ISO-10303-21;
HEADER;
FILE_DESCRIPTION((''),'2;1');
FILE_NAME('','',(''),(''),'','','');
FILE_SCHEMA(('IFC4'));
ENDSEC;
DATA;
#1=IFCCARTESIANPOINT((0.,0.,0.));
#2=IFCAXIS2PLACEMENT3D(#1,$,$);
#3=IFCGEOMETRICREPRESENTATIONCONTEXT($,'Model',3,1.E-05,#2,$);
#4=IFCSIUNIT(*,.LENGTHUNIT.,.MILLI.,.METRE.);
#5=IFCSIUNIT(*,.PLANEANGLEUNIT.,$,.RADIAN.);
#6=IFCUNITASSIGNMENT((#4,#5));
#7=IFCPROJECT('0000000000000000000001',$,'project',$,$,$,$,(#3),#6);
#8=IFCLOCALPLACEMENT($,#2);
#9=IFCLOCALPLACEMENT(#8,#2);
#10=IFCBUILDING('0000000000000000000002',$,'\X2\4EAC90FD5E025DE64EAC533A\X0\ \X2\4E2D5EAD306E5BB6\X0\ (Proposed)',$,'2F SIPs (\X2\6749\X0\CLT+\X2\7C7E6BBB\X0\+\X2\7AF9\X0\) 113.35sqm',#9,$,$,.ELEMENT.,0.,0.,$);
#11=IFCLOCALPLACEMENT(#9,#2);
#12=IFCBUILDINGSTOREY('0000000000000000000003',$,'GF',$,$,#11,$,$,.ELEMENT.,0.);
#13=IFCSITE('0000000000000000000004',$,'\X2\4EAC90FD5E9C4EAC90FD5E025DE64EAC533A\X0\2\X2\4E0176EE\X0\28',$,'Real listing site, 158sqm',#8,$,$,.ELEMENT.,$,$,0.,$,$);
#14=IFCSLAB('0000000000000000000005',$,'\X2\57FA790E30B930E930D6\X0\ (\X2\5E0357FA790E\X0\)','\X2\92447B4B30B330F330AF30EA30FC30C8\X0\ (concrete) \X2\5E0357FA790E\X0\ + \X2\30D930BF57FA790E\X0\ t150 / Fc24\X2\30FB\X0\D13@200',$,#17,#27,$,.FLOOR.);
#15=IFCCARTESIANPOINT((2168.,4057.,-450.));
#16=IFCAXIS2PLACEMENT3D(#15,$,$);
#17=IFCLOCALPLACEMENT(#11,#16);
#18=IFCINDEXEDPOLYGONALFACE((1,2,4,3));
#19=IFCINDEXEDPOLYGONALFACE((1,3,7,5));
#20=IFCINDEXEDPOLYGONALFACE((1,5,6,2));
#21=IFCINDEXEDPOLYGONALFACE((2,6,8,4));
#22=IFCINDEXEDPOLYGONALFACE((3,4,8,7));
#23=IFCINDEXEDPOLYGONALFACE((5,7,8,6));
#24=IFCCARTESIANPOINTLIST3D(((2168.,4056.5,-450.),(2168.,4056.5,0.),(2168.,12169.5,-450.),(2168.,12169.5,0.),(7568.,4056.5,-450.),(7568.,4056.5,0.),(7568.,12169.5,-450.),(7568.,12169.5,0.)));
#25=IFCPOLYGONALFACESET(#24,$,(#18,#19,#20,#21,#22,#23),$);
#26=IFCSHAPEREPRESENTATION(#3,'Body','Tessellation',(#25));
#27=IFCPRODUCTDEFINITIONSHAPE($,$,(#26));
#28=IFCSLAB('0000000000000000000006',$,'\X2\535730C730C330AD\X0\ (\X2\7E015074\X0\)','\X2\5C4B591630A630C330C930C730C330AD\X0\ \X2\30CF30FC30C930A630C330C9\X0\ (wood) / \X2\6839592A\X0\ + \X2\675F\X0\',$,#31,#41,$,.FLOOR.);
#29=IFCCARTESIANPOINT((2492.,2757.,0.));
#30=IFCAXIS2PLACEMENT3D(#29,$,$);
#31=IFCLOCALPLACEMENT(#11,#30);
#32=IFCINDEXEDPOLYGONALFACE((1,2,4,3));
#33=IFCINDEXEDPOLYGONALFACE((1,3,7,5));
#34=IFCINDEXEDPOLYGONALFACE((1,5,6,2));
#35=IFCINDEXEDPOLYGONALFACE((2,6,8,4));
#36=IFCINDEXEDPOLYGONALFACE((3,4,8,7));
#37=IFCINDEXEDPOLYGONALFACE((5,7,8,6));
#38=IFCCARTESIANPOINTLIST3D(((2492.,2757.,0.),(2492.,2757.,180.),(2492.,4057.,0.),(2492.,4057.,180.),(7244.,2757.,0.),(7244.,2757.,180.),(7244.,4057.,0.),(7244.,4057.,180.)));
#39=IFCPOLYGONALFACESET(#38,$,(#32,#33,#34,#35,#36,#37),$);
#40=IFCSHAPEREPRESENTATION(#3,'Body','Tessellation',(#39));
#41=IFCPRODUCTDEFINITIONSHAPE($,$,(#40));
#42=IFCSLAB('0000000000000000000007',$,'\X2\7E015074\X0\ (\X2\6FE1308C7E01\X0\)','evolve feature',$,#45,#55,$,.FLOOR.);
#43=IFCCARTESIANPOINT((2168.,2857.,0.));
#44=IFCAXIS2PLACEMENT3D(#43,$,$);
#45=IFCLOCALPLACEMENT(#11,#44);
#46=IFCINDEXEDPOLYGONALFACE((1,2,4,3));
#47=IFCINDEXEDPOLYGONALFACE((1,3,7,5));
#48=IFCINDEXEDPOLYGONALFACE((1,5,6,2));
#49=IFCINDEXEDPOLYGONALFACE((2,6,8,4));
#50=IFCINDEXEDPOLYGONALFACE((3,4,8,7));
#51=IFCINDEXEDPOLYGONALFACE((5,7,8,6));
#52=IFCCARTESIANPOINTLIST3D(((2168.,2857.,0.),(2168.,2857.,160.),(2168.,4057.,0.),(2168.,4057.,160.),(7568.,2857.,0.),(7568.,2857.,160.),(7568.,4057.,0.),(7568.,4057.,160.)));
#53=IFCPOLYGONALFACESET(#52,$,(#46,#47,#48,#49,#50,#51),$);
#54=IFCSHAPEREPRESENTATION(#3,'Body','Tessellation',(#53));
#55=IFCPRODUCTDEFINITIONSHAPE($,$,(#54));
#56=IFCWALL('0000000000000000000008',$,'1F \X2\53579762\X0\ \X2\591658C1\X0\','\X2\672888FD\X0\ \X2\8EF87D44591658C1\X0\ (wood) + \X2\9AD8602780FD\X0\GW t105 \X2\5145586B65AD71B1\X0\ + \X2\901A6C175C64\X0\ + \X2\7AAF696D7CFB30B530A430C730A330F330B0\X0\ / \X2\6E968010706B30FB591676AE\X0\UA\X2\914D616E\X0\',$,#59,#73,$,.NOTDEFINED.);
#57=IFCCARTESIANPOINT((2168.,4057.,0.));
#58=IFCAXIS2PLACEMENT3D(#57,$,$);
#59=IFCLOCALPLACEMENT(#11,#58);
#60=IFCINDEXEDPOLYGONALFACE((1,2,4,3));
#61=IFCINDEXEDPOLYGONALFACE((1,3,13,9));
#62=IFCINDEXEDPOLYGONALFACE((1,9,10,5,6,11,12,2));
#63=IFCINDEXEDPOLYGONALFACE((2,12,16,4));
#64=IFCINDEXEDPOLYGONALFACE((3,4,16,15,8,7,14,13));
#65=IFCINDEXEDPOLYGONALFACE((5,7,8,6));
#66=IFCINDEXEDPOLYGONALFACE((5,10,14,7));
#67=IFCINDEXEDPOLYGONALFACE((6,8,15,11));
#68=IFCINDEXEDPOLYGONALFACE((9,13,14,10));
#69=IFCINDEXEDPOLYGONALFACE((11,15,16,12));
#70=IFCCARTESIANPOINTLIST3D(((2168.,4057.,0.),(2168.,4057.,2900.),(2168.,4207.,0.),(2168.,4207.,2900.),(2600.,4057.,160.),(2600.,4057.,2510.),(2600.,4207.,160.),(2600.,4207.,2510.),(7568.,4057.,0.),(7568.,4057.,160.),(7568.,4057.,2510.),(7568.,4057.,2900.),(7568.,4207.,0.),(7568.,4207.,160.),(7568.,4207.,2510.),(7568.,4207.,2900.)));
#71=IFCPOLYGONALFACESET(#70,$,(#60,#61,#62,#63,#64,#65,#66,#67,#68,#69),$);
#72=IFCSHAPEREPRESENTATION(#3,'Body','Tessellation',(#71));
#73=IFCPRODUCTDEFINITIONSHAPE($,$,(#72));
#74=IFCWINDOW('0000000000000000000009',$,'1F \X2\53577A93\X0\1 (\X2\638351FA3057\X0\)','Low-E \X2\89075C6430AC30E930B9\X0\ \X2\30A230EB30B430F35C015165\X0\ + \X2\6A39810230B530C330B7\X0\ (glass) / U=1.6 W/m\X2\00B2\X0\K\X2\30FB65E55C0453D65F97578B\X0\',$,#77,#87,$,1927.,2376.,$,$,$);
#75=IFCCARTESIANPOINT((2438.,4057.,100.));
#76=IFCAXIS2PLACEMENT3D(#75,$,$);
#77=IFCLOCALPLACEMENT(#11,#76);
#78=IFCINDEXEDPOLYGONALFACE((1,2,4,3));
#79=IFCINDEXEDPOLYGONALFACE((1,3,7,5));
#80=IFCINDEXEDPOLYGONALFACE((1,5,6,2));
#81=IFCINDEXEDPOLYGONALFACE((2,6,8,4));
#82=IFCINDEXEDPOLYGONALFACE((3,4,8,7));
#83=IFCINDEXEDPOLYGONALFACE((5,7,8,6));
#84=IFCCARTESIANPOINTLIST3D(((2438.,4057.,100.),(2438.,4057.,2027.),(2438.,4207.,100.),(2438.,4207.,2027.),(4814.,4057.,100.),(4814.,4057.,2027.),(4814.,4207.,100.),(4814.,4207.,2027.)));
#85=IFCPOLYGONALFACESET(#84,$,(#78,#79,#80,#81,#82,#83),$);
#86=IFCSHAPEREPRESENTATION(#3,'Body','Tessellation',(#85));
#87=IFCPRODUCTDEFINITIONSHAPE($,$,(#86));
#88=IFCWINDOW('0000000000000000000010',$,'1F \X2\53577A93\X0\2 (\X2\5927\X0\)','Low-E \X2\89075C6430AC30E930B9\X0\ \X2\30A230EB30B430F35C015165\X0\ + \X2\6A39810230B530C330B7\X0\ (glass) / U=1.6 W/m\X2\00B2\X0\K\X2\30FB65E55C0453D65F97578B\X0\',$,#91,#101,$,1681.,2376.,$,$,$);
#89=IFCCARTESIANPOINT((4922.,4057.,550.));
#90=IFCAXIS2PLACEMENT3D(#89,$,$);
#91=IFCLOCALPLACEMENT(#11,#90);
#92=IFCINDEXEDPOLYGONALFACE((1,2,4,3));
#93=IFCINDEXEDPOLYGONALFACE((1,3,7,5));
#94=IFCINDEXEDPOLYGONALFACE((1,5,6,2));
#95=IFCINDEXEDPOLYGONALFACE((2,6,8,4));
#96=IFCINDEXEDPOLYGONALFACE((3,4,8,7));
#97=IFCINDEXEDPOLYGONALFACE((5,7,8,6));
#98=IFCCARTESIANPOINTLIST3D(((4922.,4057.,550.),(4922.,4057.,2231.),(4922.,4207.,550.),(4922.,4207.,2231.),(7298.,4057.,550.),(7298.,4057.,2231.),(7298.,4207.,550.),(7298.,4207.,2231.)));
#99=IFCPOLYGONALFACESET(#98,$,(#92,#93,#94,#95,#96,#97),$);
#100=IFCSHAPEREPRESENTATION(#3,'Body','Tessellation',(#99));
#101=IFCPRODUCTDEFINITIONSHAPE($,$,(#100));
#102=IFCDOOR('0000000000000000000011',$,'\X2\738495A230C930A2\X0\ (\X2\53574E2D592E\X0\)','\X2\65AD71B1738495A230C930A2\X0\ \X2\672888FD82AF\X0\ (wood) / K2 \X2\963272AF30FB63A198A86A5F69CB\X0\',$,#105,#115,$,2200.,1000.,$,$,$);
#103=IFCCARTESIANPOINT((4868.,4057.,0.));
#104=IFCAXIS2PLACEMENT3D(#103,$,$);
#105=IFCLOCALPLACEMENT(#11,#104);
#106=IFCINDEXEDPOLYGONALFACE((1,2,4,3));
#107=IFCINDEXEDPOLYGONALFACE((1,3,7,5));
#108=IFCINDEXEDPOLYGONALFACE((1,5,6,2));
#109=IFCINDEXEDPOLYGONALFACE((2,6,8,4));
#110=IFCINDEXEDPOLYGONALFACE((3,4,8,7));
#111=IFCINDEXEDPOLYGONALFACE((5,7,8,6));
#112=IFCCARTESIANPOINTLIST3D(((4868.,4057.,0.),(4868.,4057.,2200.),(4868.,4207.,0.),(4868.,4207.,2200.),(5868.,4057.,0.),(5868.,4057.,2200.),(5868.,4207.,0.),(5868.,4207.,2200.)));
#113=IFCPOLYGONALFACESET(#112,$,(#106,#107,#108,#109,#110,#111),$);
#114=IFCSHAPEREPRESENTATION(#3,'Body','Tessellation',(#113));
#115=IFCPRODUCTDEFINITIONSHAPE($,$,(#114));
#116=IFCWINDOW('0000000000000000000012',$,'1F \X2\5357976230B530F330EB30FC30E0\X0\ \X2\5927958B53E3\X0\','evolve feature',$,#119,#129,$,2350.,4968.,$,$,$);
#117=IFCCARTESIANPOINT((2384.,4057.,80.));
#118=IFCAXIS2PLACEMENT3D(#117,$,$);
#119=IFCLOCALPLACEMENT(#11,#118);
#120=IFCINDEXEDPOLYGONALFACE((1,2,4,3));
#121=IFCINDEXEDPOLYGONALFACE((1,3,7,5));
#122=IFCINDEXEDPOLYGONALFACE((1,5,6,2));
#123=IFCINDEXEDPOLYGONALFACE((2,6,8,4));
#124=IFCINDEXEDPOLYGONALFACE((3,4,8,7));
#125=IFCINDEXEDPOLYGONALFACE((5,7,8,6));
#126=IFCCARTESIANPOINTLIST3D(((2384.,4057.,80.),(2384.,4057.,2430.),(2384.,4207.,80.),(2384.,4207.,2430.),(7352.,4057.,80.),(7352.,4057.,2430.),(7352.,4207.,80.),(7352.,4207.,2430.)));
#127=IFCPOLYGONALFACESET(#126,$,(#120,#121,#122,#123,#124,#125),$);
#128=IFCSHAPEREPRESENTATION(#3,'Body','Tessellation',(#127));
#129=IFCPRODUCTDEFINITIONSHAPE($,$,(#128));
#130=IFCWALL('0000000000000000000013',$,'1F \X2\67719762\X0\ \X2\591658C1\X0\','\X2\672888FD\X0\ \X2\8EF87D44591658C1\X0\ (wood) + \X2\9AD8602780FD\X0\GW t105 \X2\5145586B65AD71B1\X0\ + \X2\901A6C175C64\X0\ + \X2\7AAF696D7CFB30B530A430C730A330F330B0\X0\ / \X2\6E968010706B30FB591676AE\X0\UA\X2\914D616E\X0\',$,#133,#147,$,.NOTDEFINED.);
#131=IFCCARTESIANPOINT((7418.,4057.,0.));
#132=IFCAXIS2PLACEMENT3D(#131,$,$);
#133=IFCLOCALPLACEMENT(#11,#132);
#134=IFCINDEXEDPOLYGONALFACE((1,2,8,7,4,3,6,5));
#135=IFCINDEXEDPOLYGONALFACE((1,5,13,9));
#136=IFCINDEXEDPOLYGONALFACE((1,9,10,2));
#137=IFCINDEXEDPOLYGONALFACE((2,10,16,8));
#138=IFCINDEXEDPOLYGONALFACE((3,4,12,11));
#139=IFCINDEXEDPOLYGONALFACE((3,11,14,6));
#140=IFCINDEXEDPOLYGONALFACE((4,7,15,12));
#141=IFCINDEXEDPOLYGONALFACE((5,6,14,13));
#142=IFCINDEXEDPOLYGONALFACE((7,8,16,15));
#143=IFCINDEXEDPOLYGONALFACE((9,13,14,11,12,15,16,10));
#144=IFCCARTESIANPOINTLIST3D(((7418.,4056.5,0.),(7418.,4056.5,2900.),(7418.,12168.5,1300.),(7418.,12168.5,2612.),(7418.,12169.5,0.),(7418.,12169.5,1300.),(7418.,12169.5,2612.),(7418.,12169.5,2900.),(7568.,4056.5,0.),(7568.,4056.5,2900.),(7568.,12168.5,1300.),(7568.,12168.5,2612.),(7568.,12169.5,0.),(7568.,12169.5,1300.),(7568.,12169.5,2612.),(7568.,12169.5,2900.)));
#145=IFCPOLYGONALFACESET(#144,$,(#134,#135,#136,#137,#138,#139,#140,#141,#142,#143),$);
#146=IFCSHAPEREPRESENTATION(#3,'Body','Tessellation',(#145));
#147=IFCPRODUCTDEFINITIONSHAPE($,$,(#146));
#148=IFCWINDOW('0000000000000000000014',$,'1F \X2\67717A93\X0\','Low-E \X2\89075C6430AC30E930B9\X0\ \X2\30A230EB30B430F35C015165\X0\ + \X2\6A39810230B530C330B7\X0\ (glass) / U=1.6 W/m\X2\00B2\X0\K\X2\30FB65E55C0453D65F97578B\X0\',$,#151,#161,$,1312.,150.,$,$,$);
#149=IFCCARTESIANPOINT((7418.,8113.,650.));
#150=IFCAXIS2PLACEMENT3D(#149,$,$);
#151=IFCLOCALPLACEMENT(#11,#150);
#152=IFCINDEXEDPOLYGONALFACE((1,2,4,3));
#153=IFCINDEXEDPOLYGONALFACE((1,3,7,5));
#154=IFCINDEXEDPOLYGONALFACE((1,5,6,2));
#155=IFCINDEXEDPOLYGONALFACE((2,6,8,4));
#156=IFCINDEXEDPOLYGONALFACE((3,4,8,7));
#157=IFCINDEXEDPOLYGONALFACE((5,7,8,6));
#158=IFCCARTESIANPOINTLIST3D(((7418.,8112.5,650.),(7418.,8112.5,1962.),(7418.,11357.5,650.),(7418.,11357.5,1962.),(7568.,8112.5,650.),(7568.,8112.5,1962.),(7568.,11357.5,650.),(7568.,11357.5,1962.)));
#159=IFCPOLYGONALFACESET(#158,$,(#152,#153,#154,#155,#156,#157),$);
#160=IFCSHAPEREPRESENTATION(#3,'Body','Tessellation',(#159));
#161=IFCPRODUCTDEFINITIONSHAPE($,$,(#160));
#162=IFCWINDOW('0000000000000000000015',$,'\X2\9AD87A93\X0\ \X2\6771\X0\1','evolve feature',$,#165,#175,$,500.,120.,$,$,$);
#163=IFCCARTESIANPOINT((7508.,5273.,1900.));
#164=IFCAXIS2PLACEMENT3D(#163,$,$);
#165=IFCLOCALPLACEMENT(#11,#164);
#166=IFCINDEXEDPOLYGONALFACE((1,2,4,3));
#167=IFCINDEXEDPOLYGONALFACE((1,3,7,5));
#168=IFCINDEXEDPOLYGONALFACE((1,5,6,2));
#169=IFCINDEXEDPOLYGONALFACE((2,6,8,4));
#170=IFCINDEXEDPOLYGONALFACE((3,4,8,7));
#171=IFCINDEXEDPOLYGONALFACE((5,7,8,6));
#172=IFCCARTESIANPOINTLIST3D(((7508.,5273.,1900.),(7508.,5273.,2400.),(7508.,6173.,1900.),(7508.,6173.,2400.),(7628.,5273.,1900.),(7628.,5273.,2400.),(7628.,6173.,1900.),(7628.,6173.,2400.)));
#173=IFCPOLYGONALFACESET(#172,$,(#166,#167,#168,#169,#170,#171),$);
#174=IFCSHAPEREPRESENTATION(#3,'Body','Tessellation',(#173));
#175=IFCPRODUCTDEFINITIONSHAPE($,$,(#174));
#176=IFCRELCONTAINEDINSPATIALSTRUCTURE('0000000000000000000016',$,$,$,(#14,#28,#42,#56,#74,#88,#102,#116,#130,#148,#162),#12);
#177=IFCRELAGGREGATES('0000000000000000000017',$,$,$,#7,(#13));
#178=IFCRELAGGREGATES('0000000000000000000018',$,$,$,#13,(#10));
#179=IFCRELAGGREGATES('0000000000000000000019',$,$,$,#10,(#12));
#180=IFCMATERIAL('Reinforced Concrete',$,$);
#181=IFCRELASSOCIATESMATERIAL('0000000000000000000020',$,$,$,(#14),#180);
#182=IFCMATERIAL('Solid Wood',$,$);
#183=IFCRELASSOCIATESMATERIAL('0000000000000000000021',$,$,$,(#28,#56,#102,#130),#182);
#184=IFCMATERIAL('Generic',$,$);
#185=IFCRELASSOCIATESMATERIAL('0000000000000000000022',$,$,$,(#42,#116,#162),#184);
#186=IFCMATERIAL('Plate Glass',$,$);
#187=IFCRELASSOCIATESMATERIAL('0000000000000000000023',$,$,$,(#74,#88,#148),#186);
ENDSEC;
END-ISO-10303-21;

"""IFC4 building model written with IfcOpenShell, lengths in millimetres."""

from ifc_helpers import new_model, si_unit, frame, frame_2d, origin, place, context, project, spatial, rectangle, extrude, material, element, fill, save


model = new_model("IFC4")

# Units and contexts
model_context = context("Model", 3, precision=1e-05, world=origin())
ifc_project = project(units=[si_unit("LENGTHUNIT", "METRE", prefix="MILLI"), si_unit("PLANEANGLEUNIT", "RADIAN")], contexts=[model_context])

# Site, building, storey
site_placement = place(None, origin())
site = spatial("IfcSite", under=ifc_project, at=site_placement, Name="京都府京都市左京区2丁目28", ObjectType="Real listing site, 158sqm", CompositionType="ELEMENT", RefElevation=0.0)
building_placement = place(site_placement, origin())
building = spatial("IfcBuilding", under=site, at=building_placement, Name="京都市左京区 中庭の家 (Proposed)", ObjectType="2F SIPs (杉CLT+籾殻+竹) 113.35sqm", CompositionType="ELEMENT", ElevationOfRefHeight=0.0, ElevationOfTerrain=0.0)
storey_placement = place(building_placement, origin())
storey = spatial("IfcBuildingStorey", under=building, at=storey_placement, Name="GF", CompositionType="ELEMENT", Elevation=0.0)

# Slabs
ifc_material_1 = material(Name="Reinforced Concrete")
slab_1_placement = place(storey_placement, frame((2168.0, 4057.0, -450.0)))
element("IfcSlab", 1, at=slab_1_placement, inside=storey, material=ifc_material_1, Name="基礎スラブ (布基礎)", Description="鉄筋コンクリート (concrete) 布基礎 + ベタ基礎 t150 / Fc24・D13@200", PredefinedType="FLOOR", context=model_context, shape_type="SweptSolid", body=[
    extrude(rectangle(XDim=5400.0, YDim=8113.0, at=frame_2d((2700.0, 4056.0))), frame((2168.0, 4057.0, -450.0)), (0.0, 0.0, 1.0), 450.0),
])
ifc_material_2 = material(Name="Solid Wood")
slab_2_placement = place(storey_placement, frame((2492.0, 2757.0, 0.0)))
element("IfcSlab", 2, at=slab_2_placement, inside=storey, material=ifc_material_2, Name="南デッキ (縁側)", Description="屋外ウッドデッキ ハードウッド (wood) / 根太 + 束", PredefinedType="FLOOR", context=model_context, shape_type="SweptSolid", body=[
    extrude(rectangle(XDim=4752.0, YDim=1300.0, at=frame_2d((2376.0, 650.0))), frame((2492.0, 2757.0, 0.0)), (0.0, 0.0, 1.0), 180.0),
])
ifc_material_3 = material(Name="Generic")
slab_3_placement = place(storey_placement, frame((2168.0, 2857.0, 0.0)))
element("IfcSlab", 3, at=slab_3_placement, inside=storey, material=ifc_material_3, Name="縁側 (濡れ縁)", Description="evolve feature", PredefinedType="FLOOR", context=model_context, shape_type="SweptSolid", body=[
    extrude(rectangle(XDim=5400.0, YDim=1200.0, at=frame_2d((2700.0, 600.0))), frame((2168.0, 2857.0, 0.0)), (0.0, 0.0, 1.0), 160.0),
])

# Wall, openings, windows, door
wall_1_placement = place(storey_placement, frame((2168.0, 4057.0, 0.0)))
wall_1 = element("IfcWall", 4, at=wall_1_placement, inside=storey, material=ifc_material_2, Name="1F 南面 外壁", Description="木製 軸組外壁 (wood) + 高性能GW t105 充填断熱 + 通気層 + 窯業系サイディング / 準耐火・外皮UA配慮", PredefinedType="NOTDEFINED", context=model_context, shape_type="SweptSolid", body=[
    extrude(rectangle(XDim=5400.0, YDim=150.0, at=frame_2d((2700.0, 75.0))), frame((2168.0, 4057.0, 0.0)), (0.0, 0.0, 1.0), 2900.0),
])
opening_1_placement = place(storey_placement, frame((2438.0, 4057.0, 100.0)))
opening_1 = element("IfcOpeningElement", 5, at=opening_1_placement, cuts=wall_1, PredefinedType="NOTDEFINED", context=model_context, shape_type="SweptSolid", body=[
    extrude(rectangle(XDim=2376.0, YDim=150.0, at=frame_2d((1188.0, 75.0))), frame((2438.0, 4057.0, 100.0)), (0.0, 0.0, 1.0), 1927.0),
])
opening_2_placement = place(storey_placement, frame((4922.0, 4057.0, 550.0)))
opening_2 = element("IfcOpeningElement", 6, at=opening_2_placement, cuts=wall_1, PredefinedType="NOTDEFINED", context=model_context, shape_type="SweptSolid", body=[
    extrude(rectangle(XDim=2376.0, YDim=150.0, at=frame_2d((1188.0, 75.0))), frame((4922.0, 4057.0, 550.0)), (0.0, 0.0, 1.0), 1681.0),
])
opening_3_placement = place(storey_placement, frame((4868.0, 4057.0, 0.0)))
opening_3 = element("IfcOpeningElement", 7, at=opening_3_placement, cuts=wall_1, PredefinedType="NOTDEFINED", context=model_context, shape_type="SweptSolid", body=[
    extrude(rectangle(XDim=1000.0, YDim=150.0, at=frame_2d((500.0, 75.0))), frame((4868.0, 4057.0, 0.0)), (0.0, 0.0, 1.0), 2200.0),
])
opening_4_placement = place(storey_placement, frame((2384.0, 4057.0, 80.0)))
opening_4 = element("IfcOpeningElement", 8, at=opening_4_placement, cuts=wall_1, PredefinedType="NOTDEFINED", context=model_context, shape_type="SweptSolid", body=[
    extrude(rectangle(XDim=4968.0, YDim=150.0, at=frame_2d((2484.0, 75.0))), frame((2384.0, 4057.0, 80.0)), (0.0, 0.0, 1.0), 2350.0),
])
ifc_material_4 = material(Name="Plate Glass")
window_1_placement = place(storey_placement, frame((2438.0, 4057.0, 100.0)))
window_1 = element("IfcWindow", 9, at=window_1_placement, inside=storey, material=ifc_material_4, Name="1F 南窓1 (掃出し)", Description="Low-E 複層ガラス アルゴン封入 + 樹脂サッシ (glass) / U=1.6 W/m²K・日射取得型", OverallHeight=1927.0, OverallWidth=2376.0, context=model_context, shape_type="SweptSolid", body=[
    extrude(rectangle(XDim=2376.0, YDim=150.0, at=frame_2d((1188.0, 75.0))), frame((2438.0, 4057.0, 100.0)), (0.0, 0.0, 1.0), 1927.0),
])
fill(opening_1, window_1)
window_2_placement = place(storey_placement, frame((4922.0, 4057.0, 550.0)))
window_2 = element("IfcWindow", 10, at=window_2_placement, inside=storey, material=ifc_material_4, Name="1F 南窓2 (大)", Description="Low-E 複層ガラス アルゴン封入 + 樹脂サッシ (glass) / U=1.6 W/m²K・日射取得型", OverallHeight=1681.0, OverallWidth=2376.0, context=model_context, shape_type="SweptSolid", body=[
    extrude(rectangle(XDim=2376.0, YDim=150.0, at=frame_2d((1188.0, 75.0))), frame((4922.0, 4057.0, 550.0)), (0.0, 0.0, 1.0), 1681.0),
])
fill(opening_2, window_2)
door_placement = place(storey_placement, frame((4868.0, 4057.0, 0.0)))
door = element("IfcDoor", 11, at=door_placement, inside=storey, material=ifc_material_2, Name="玄関ドア (南中央)", Description="断熱玄関ドア 木製芯 (wood) / K2 防犯・採風機構", OverallHeight=2200.0, OverallWidth=1000.0, context=model_context, shape_type="SweptSolid", body=[
    extrude(rectangle(XDim=1000.0, YDim=150.0, at=frame_2d((500.0, 75.0))), frame((4868.0, 4057.0, 0.0)), (0.0, 0.0, 1.0), 2200.0),
])
fill(opening_3, door)
window_3_placement = place(storey_placement, frame((2384.0, 4057.0, 80.0)))
window_3 = element("IfcWindow", 12, at=window_3_placement, inside=storey, material=ifc_material_3, Name="1F 南面サンルーム 大開口", Description="evolve feature", OverallHeight=2350.0, OverallWidth=4968.0, context=model_context, shape_type="SweptSolid", body=[
    extrude(rectangle(XDim=4968.0, YDim=150.0, at=frame_2d((2484.0, 75.0))), frame((2384.0, 4057.0, 80.0)), (0.0, 0.0, 1.0), 2350.0),
])
fill(opening_4, window_3)

# Wall, openings, windows
wall_2_placement = place(storey_placement, frame((7418.0, 4057.0, 0.0)))
wall_2 = element("IfcWall", 13, at=wall_2_placement, inside=storey, material=ifc_material_2, Name="1F 東面 外壁", Description="木製 軸組外壁 (wood) + 高性能GW t105 充填断熱 + 通気層 + 窯業系サイディング / 準耐火・外皮UA配慮", PredefinedType="NOTDEFINED", context=model_context, shape_type="SweptSolid", body=[
    extrude(rectangle(XDim=150.0, YDim=8113.0, at=frame_2d((75.0, 4056.0))), frame((7418.0, 4057.0, 0.0)), (0.0, 0.0, 1.0), 2900.0),
])
opening_5_placement = place(storey_placement, frame((7418.0, 8113.0, 650.0)))
opening_5 = element("IfcOpeningElement", 14, at=opening_5_placement, cuts=wall_2, PredefinedType="NOTDEFINED", context=model_context, shape_type="SweptSolid", body=[
    extrude(rectangle(XDim=150.0, YDim=3245.0, at=frame_2d((75.0, 1622.0))), frame((7418.0, 8113.0, 650.0)), (0.0, 0.0, 1.0), 1312.0),
])
opening_6_placement = place(storey_placement, frame((7508.0, 5273.0, 1900.0)))
opening_6 = element("IfcOpeningElement", 15, at=opening_6_placement, cuts=wall_2, PredefinedType="NOTDEFINED", context=model_context, shape_type="SweptSolid", body=[
    extrude(rectangle(XDim=120.0, YDim=900.0, at=frame_2d((60.0, 450.0))), frame((7508.0, 5273.0, 1900.0)), (0.0, 0.0, 1.0), 500.0),
])
window_4_placement = place(storey_placement, frame((7418.0, 8113.0, 650.0)))
window_4 = element("IfcWindow", 16, at=window_4_placement, inside=storey, material=ifc_material_4, Name="1F 東窓", Description="Low-E 複層ガラス アルゴン封入 + 樹脂サッシ (glass) / U=1.6 W/m²K・日射取得型", OverallHeight=1312.0, OverallWidth=150.0, context=model_context, shape_type="SweptSolid", body=[
    extrude(rectangle(XDim=150.0, YDim=3245.0, at=frame_2d((75.0, 1622.0))), frame((7418.0, 8113.0, 650.0)), (0.0, 0.0, 1.0), 1312.0),
])
fill(opening_5, window_4)
window_5_placement = place(storey_placement, frame((7508.0, 5273.0, 1900.0)))
window_5 = element("IfcWindow", 17, at=window_5_placement, inside=storey, material=ifc_material_3, Name="高窓 東1", Description="evolve feature", OverallHeight=500.0, OverallWidth=120.0, context=model_context, shape_type="SweptSolid", body=[
    extrude(rectangle(XDim=120.0, YDim=900.0, at=frame_2d((60.0, 450.0))), frame((7508.0, 5273.0, 1900.0)), (0.0, 0.0, 1.0), 500.0),
])
fill(opening_6, window_5)

save(model, "model.ifc")
